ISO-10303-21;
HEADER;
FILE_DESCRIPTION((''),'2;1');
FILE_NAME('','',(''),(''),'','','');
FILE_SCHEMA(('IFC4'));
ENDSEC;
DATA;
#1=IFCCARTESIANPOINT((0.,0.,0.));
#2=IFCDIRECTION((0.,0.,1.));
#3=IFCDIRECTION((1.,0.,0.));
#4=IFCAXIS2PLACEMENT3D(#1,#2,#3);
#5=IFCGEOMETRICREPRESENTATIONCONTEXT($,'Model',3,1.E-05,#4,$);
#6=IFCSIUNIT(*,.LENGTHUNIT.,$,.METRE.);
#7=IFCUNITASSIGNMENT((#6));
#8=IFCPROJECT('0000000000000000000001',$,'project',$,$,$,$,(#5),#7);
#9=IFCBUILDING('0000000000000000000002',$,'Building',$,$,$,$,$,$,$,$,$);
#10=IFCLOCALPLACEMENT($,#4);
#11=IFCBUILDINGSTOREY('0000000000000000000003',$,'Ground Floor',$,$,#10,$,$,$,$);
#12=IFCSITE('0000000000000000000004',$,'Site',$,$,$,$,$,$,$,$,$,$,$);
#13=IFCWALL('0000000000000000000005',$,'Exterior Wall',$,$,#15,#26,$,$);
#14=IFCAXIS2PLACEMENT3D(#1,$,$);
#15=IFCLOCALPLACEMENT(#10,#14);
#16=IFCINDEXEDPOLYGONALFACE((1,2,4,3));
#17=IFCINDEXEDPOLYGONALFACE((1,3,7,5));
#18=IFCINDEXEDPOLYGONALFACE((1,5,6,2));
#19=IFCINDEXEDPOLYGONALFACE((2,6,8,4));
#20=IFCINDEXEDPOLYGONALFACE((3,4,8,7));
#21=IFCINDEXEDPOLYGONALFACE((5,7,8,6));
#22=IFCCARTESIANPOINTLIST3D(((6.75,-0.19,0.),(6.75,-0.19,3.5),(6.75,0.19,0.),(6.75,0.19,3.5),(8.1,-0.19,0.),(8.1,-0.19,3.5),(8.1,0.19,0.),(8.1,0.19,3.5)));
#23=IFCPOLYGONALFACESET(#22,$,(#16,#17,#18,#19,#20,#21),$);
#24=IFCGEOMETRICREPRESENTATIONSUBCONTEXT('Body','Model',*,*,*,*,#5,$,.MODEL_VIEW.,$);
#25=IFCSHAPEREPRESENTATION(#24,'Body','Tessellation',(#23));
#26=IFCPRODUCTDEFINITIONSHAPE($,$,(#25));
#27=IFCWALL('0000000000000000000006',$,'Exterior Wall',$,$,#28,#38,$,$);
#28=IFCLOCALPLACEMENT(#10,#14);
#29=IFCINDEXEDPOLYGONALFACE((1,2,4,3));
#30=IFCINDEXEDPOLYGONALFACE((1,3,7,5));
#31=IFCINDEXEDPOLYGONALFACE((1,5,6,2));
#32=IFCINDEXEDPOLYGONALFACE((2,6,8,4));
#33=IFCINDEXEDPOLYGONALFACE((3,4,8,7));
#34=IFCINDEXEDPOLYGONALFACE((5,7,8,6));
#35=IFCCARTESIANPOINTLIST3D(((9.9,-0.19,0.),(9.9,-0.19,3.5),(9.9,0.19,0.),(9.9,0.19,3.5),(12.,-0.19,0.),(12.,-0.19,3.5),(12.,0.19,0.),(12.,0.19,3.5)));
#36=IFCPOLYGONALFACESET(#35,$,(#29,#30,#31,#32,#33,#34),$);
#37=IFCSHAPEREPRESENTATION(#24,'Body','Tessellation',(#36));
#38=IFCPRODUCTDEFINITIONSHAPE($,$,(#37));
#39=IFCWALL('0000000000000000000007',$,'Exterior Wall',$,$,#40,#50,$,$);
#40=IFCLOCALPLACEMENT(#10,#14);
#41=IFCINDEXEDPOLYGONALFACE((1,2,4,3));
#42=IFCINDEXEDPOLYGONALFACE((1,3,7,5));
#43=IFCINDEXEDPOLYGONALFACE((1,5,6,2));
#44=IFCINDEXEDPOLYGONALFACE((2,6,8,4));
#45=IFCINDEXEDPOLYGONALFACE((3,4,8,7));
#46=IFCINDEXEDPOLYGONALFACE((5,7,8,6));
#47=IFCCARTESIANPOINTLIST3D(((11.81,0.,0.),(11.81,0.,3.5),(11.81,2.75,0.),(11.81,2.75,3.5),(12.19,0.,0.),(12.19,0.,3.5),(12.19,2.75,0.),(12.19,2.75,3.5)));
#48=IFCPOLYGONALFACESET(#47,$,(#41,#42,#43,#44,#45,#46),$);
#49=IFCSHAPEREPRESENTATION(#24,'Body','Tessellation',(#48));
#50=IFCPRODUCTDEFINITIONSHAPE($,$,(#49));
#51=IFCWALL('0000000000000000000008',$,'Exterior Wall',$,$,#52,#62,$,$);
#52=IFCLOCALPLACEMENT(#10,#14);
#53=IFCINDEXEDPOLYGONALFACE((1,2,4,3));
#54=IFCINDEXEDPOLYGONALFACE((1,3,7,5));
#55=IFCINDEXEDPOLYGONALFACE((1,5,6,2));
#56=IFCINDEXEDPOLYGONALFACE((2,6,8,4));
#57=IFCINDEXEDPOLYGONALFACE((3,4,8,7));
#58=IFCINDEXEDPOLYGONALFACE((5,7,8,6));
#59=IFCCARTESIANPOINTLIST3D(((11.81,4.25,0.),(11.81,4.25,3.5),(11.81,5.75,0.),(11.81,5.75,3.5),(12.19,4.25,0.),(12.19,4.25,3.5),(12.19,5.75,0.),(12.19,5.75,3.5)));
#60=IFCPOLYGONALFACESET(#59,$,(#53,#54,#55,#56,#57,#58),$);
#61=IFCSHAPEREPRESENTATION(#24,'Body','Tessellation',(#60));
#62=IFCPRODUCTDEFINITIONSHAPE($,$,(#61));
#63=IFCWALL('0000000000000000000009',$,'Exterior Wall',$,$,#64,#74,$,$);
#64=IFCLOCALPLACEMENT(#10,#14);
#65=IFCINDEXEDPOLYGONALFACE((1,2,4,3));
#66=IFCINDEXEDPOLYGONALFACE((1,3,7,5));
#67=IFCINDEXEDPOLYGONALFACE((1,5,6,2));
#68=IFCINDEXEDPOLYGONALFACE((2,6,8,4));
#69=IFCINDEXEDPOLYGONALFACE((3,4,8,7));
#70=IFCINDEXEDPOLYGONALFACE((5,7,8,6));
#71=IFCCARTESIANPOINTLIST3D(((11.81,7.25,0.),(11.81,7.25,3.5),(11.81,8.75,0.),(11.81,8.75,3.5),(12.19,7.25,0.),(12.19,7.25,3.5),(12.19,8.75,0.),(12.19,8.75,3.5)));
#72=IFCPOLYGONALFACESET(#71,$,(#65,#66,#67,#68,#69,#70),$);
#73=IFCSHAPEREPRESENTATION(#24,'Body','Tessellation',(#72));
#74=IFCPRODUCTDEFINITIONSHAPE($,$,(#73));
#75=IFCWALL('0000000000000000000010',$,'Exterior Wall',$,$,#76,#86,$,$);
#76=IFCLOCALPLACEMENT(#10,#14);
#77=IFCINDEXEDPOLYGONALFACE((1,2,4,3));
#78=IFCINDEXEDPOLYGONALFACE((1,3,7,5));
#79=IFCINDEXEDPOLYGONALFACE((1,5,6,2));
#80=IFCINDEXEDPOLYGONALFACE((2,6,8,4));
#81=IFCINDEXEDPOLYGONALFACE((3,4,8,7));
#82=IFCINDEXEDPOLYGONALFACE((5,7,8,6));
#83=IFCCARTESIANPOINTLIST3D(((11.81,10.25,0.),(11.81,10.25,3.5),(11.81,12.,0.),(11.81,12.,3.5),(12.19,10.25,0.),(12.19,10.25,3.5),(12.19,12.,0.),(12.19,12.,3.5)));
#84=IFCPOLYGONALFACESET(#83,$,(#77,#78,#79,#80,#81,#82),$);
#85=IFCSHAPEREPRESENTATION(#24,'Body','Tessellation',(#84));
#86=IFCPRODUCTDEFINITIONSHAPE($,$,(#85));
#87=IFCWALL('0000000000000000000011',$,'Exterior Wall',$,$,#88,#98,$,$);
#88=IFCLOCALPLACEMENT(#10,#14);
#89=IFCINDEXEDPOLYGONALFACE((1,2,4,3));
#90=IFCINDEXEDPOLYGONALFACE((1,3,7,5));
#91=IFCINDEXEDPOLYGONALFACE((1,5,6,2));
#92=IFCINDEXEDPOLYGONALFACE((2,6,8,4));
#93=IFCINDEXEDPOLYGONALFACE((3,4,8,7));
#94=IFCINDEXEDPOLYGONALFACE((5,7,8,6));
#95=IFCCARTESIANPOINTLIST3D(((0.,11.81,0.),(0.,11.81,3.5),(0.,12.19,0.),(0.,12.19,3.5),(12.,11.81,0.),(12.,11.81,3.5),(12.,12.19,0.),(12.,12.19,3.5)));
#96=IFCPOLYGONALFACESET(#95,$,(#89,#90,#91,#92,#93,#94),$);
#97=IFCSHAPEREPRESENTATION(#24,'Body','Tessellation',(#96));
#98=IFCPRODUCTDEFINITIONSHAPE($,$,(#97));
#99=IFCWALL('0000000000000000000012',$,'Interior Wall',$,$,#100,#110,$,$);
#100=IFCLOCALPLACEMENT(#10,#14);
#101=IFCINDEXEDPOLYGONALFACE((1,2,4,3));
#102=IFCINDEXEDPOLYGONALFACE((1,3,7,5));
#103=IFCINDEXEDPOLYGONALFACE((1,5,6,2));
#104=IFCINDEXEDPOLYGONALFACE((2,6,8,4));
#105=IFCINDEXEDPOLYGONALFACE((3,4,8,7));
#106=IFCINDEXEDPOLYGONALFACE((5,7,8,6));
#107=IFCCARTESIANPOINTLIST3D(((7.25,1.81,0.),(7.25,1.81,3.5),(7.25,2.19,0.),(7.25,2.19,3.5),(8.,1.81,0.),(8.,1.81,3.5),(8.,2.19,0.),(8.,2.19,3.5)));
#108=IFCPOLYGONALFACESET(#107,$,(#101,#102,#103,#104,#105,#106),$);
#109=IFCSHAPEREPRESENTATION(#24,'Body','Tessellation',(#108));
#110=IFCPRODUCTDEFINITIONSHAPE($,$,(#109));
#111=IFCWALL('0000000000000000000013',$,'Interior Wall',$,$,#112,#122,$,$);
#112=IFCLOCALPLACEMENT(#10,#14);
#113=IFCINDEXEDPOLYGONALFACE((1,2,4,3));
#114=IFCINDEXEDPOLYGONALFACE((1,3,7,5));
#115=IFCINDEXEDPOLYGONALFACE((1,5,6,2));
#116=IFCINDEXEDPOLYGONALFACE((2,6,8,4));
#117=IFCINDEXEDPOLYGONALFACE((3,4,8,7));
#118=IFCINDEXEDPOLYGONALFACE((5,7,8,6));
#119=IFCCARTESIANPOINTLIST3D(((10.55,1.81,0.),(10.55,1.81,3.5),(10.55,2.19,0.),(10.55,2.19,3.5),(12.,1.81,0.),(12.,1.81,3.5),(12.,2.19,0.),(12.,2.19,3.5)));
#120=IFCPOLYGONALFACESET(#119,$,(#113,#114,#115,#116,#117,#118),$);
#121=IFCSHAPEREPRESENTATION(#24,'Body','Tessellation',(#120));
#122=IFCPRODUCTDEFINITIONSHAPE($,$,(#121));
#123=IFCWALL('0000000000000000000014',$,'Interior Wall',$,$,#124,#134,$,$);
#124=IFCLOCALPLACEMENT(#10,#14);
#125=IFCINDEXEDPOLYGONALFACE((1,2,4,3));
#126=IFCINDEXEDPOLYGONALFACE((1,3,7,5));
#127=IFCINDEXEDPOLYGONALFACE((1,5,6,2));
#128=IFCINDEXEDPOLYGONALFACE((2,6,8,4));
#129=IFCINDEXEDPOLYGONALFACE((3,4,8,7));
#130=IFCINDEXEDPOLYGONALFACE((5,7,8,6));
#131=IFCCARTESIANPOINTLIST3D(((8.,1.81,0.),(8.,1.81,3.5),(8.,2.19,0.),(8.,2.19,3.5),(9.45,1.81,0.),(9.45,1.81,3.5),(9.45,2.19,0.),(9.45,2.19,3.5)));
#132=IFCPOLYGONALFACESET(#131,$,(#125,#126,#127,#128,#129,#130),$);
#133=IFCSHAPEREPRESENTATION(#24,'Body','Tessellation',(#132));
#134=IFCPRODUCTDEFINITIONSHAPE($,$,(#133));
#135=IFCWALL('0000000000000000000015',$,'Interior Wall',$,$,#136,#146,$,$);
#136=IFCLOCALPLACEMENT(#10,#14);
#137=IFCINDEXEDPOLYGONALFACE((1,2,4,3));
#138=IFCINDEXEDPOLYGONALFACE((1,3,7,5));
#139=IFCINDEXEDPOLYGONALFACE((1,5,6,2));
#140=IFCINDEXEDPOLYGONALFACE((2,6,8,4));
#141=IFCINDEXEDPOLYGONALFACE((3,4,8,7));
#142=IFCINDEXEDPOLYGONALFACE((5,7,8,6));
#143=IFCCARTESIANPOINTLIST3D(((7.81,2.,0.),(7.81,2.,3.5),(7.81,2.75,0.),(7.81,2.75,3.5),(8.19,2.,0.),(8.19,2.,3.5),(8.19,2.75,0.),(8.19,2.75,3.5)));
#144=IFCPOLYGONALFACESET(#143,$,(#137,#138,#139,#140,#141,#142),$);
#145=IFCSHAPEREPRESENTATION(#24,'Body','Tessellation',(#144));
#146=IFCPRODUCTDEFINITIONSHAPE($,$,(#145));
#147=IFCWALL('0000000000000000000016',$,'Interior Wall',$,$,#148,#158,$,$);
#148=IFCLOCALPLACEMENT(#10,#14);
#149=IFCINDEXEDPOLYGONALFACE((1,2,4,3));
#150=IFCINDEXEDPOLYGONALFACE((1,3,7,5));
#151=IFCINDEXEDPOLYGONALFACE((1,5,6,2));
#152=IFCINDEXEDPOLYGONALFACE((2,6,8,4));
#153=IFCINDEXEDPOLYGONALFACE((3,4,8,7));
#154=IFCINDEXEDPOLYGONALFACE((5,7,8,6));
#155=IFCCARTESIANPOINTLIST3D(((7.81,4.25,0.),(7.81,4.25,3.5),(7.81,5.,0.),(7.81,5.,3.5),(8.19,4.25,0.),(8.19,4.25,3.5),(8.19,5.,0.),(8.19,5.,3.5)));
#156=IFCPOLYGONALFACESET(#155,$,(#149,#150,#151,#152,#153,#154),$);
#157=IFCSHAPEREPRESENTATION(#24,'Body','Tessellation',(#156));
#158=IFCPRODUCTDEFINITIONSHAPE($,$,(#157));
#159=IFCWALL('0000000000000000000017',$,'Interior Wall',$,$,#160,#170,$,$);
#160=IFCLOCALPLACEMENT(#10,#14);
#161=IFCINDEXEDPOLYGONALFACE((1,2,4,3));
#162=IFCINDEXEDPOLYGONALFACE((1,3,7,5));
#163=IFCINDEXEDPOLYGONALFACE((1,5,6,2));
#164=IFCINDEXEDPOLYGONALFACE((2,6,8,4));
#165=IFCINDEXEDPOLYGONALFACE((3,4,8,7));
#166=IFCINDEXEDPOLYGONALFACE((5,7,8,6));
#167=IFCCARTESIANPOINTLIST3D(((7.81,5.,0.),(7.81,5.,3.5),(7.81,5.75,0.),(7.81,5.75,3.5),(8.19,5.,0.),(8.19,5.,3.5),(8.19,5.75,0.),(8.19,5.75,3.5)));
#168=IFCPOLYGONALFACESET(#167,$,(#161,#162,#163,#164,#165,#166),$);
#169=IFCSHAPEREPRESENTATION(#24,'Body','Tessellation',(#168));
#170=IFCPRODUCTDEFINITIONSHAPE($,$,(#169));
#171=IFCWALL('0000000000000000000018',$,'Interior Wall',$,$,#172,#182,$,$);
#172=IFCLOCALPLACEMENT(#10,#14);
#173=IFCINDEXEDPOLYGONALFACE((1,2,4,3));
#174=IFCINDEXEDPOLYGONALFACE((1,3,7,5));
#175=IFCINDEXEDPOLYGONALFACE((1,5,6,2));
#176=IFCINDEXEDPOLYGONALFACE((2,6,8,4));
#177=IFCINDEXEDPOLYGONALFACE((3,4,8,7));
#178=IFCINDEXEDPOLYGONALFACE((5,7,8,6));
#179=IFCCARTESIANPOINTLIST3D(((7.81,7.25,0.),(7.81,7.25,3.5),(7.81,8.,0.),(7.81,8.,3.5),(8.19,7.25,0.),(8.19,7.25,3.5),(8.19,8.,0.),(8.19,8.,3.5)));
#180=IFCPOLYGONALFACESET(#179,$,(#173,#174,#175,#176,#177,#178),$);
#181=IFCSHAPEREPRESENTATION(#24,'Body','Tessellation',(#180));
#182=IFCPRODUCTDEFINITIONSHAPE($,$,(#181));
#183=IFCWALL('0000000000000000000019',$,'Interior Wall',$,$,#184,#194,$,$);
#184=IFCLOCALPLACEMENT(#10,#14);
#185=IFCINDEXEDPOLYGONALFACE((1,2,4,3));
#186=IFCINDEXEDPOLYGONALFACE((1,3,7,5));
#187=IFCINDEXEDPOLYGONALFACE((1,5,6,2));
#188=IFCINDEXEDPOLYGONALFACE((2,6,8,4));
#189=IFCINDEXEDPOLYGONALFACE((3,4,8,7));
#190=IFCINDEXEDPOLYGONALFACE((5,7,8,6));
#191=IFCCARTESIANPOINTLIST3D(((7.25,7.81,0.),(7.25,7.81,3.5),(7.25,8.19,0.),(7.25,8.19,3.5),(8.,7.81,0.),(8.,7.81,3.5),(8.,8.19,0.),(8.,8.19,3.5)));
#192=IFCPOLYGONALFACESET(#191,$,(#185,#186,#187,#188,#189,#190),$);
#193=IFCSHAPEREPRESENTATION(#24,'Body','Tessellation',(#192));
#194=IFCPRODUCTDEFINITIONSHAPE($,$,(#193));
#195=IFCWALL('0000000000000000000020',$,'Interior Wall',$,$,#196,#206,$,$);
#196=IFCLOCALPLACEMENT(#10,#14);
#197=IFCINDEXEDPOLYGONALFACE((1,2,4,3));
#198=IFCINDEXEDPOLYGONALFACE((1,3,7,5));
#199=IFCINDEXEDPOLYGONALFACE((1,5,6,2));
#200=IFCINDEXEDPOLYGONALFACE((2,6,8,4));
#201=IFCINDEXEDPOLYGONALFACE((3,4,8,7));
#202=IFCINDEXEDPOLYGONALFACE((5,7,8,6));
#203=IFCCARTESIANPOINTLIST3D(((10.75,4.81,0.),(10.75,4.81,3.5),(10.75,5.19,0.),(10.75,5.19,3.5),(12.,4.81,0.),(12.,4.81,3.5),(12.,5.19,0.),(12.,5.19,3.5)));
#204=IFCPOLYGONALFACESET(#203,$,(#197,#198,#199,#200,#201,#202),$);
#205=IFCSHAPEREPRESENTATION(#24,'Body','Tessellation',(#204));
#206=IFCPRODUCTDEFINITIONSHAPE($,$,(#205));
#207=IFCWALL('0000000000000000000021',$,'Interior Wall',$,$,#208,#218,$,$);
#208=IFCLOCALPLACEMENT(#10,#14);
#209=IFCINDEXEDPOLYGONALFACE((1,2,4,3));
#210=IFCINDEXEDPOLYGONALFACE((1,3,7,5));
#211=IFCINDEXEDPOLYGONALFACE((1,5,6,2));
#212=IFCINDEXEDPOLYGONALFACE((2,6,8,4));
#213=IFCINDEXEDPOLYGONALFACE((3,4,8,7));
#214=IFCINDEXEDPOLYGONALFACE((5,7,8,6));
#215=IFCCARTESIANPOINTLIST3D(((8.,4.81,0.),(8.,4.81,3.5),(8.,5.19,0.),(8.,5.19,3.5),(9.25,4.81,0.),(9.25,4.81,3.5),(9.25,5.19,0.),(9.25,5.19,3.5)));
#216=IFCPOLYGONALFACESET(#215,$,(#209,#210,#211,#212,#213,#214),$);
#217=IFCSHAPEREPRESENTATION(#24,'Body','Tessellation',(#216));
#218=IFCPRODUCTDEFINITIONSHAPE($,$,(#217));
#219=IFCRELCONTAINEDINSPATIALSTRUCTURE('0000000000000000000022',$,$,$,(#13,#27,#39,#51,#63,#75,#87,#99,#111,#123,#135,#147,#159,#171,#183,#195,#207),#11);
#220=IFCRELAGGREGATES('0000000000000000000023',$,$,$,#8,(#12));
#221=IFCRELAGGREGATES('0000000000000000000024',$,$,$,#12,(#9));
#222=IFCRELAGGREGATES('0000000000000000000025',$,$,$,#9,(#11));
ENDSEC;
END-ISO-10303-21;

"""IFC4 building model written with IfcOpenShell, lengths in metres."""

from ifc_helpers import new_model, si_unit, frame, origin_with_axes, place, context, subcontext, project, spatial, indexed_curve, outline, extrude, element, save


model = new_model("IFC4")

# Units and contexts
model_context = context("Model", 3, precision=1e-05, world=origin_with_axes())
body_context = subcontext(model_context, "Body", "Model", "MODEL_VIEW")
ifc_project = project(units=[si_unit("LENGTHUNIT", "METRE")], contexts=[model_context])

# Site, building, storey
site = spatial("IfcSite", under=ifc_project, Name="Site")
building = spatial("IfcBuilding", under=site, Name="Building")
storey_placement = place(None, origin_with_axes())
storey = spatial("IfcBuildingStorey", under=building, at=storey_placement, Name="Ground Floor")

# Walls
wall_1_placement = place(storey_placement, frame((6.75, 0.0, 0.0), z_axis=(0.0, 0.0, 1.0), x_axis=(1.0, 0.0, 0.0)))
element("IfcWall", 1, at=wall_1_placement, inside=storey, Name="Exterior Wall", context=body_context, shape_type="SweptSolid", body=[
    extrude(outline(indexed_curve([(0.0, 0.0), (0.0, 0.38), (1.35, 0.38), (1.35, 0.0), (0.0, 0.0)], self_intersect=False)), frame((0.0, -0.19, 0.0), z_axis=(0.0, 0.0, 1.0), x_axis=(1.0, 0.0, 0.0)), (0.0, 0.0, 1.0), 3.5),
])
wall_2_placement = place(storey_placement, frame((9.9, 0.0, 0.0), z_axis=(0.0, 0.0, 1.0), x_axis=(1.0, 0.0, 0.0)))
element("IfcWall", 2, at=wall_2_placement, inside=storey, Name="Exterior Wall", context=body_context, shape_type="SweptSolid", body=[
    extrude(outline(indexed_curve([(0.0, 0.0), (0.0, 0.38), (2.1, 0.38), (2.1, 0.0), (0.0, 0.0)], self_intersect=False)), frame((0.0, -0.19, 0.0), z_axis=(0.0, 0.0, 1.0), x_axis=(1.0, 0.0, 0.0)), (0.0, 0.0, 1.0), 3.5),
])
wall_3_placement = place(storey_placement, frame((12.0, 0.0, 0.0), z_axis=(0.0, 0.0, 1.0), x_axis=(0.0, 1.0, 0.0)))
element("IfcWall", 3, at=wall_3_placement, inside=storey, Name="Exterior Wall", context=body_context, shape_type="SweptSolid", body=[
    extrude(outline(indexed_curve([(0.0, 0.0), (0.0, 0.38), (2.75, 0.38), (2.75, 0.0), (0.0, 0.0)], self_intersect=False)), frame((0.0, -0.19, 0.0), z_axis=(0.0, 0.0, 1.0), x_axis=(1.0, 0.0, 0.0)), (0.0, 0.0, 1.0), 3.5),
])
for number, where, z_axis, x_axis, name in (
    (4, (12.0, 4.25, 0.0), (0.0, 0.0, 1.0), (0.0, 1.0, 0.0), "Exterior Wall"),
    (5, (12.0, 7.25, 0.0), (0.0, 0.0, 1.0), (0.0, 1.0, 0.0), "Exterior Wall"),
):
    element("IfcWall", number, at=place(storey_placement, frame(where, z_axis=z_axis, x_axis=x_axis)), inside=storey, Name=name, context=body_context, shape_type="SweptSolid", body=[
        extrude(outline(indexed_curve([(0.0, 0.0), (0.0, 0.38), (1.5, 0.38), (1.5, 0.0), (0.0, 0.0)], self_intersect=False)), frame((0.0, -0.19, 0.0), z_axis=(0.0, 0.0, 1.0), x_axis=(1.0, 0.0, 0.0)), (0.0, 0.0, 1.0), 3.5),
    ])
wall_4_placement = place(storey_placement, frame((12.0, 10.25, 0.0), z_axis=(0.0, 0.0, 1.0), x_axis=(0.0, 1.0, 0.0)))
element("IfcWall", 6, at=wall_4_placement, inside=storey, Name="Exterior Wall", context=body_context, shape_type="SweptSolid", body=[
    extrude(outline(indexed_curve([(0.0, 0.0), (0.0, 0.38), (1.75, 0.38), (1.75, 0.0), (0.0, 0.0)], self_intersect=False)), frame((0.0, -0.19, 0.0), z_axis=(0.0, 0.0, 1.0), x_axis=(1.0, 0.0, 0.0)), (0.0, 0.0, 1.0), 3.5),
])
wall_5_placement = place(storey_placement, frame((12.0, 12.0, 0.0), z_axis=(0.0, 0.0, 1.0), x_axis=(-1.0, 0.0, 0.0)))
element("IfcWall", 7, at=wall_5_placement, inside=storey, Name="Exterior Wall", context=body_context, shape_type="SweptSolid", body=[
    extrude(outline(indexed_curve([(0.0, 0.0), (0.0, 0.38), (12.0, 0.38), (12.0, 0.0), (0.0, 0.0)], self_intersect=False)), frame((0.0, -0.19, 0.0), z_axis=(0.0, 0.0, 1.0), x_axis=(1.0, 0.0, 0.0)), (0.0, 0.0, 1.0), 3.5),
])
wall_6_placement = place(storey_placement, frame((8.0, 2.0, 0.0), z_axis=(0.0, 0.0, 1.0), x_axis=(-1.0, 0.0, 0.0)))
element("IfcWall", 8, at=wall_6_placement, inside=storey, Name="Interior Wall", context=body_context, shape_type="SweptSolid", body=[
    extrude(outline(indexed_curve([(0.0, 0.0), (0.0, 0.38), (0.75, 0.38), (0.75, 0.0), (0.0, 0.0)], self_intersect=False)), frame((0.0, -0.19, 0.0), z_axis=(0.0, 0.0, 1.0), x_axis=(1.0, 0.0, 0.0)), (0.0, 0.0, 1.0), 3.5),
])
for number, where, z_axis, x_axis, name in (
    (9, (12.0, 2.0, 0.0), (0.0, 0.0, 1.0), (-1.0, 0.0, 0.0), "Interior Wall"),
    (10, (9.45, 2.0, 0.0), (0.0, 0.0, 1.0), (-1.0, 0.0, 0.0), "Interior Wall"),
):
    element("IfcWall", number, at=place(storey_placement, frame(where, z_axis=z_axis, x_axis=x_axis)), inside=storey, Name=name, context=body_context, shape_type="SweptSolid", body=[
        extrude(outline(indexed_curve([(0.0, 0.0), (0.0, 0.38), (1.45, 0.38), (1.45, 0.0), (0.0, 0.0)], self_intersect=False)), frame((0.0, -0.19, 0.0), z_axis=(0.0, 0.0, 1.0), x_axis=(1.0, 0.0, 0.0)), (0.0, 0.0, 1.0), 3.5),
    ])
for number, where, z_axis, x_axis, name in (
    (11, (8.0, 2.0, 0.0), (0.0, 0.0, 1.0), (0.0, 1.0, 0.0), "Interior Wall"),
    (12, (8.0, 4.25, 0.0), (0.0, 0.0, 1.0), (0.0, 1.0, 0.0), "Interior Wall"),
    (13, (8.0, 5.0, 0.0), (0.0, 0.0, 1.0), (0.0, 1.0, 0.0), "Interior Wall"),
    (14, (8.0, 7.25, 0.0), (0.0, 0.0, 1.0), (0.0, 1.0, 0.0), "Interior Wall"),
    (15, (8.0, 8.0, 0.0), (0.0, 0.0, 1.0), (-1.0, 0.0, 0.0), "Interior Wall"),
):
    element("IfcWall", number, at=place(storey_placement, frame(where, z_axis=z_axis, x_axis=x_axis)), inside=storey, Name=name, context=body_context, shape_type="SweptSolid", body=[
        extrude(outline(indexed_curve([(0.0, 0.0), (0.0, 0.38), (0.75, 0.38), (0.75, 0.0), (0.0, 0.0)], self_intersect=False)), frame((0.0, -0.19, 0.0), z_axis=(0.0, 0.0, 1.0), x_axis=(1.0, 0.0, 0.0)), (0.0, 0.0, 1.0), 3.5),
    ])
for number, where, z_axis, x_axis, name in (
    (16, (12.0, 5.0, 0.0), (0.0, 0.0, 1.0), (-1.0, 0.0, 0.0), "Interior Wall"),
    (17, (9.25, 5.0, 0.0), (0.0, 0.0, 1.0), (-1.0, 0.0, 0.0), "Interior Wall"),
):
    element("IfcWall", number, at=place(storey_placement, frame(where, z_axis=z_axis, x_axis=x_axis)), inside=storey, Name=name, context=body_context, shape_type="SweptSolid", body=[
        extrude(outline(indexed_curve([(0.0, 0.0), (0.0, 0.38), (1.25, 0.38), (1.25, 0.0), (0.0, 0.0)], self_intersect=False)), frame((0.0, -0.19, 0.0), z_axis=(0.0, 0.0, 1.0), x_axis=(1.0, 0.0, 0.0)), (0.0, 0.0, 1.0), 3.5),
    ])

save(model, "model.ifc")
